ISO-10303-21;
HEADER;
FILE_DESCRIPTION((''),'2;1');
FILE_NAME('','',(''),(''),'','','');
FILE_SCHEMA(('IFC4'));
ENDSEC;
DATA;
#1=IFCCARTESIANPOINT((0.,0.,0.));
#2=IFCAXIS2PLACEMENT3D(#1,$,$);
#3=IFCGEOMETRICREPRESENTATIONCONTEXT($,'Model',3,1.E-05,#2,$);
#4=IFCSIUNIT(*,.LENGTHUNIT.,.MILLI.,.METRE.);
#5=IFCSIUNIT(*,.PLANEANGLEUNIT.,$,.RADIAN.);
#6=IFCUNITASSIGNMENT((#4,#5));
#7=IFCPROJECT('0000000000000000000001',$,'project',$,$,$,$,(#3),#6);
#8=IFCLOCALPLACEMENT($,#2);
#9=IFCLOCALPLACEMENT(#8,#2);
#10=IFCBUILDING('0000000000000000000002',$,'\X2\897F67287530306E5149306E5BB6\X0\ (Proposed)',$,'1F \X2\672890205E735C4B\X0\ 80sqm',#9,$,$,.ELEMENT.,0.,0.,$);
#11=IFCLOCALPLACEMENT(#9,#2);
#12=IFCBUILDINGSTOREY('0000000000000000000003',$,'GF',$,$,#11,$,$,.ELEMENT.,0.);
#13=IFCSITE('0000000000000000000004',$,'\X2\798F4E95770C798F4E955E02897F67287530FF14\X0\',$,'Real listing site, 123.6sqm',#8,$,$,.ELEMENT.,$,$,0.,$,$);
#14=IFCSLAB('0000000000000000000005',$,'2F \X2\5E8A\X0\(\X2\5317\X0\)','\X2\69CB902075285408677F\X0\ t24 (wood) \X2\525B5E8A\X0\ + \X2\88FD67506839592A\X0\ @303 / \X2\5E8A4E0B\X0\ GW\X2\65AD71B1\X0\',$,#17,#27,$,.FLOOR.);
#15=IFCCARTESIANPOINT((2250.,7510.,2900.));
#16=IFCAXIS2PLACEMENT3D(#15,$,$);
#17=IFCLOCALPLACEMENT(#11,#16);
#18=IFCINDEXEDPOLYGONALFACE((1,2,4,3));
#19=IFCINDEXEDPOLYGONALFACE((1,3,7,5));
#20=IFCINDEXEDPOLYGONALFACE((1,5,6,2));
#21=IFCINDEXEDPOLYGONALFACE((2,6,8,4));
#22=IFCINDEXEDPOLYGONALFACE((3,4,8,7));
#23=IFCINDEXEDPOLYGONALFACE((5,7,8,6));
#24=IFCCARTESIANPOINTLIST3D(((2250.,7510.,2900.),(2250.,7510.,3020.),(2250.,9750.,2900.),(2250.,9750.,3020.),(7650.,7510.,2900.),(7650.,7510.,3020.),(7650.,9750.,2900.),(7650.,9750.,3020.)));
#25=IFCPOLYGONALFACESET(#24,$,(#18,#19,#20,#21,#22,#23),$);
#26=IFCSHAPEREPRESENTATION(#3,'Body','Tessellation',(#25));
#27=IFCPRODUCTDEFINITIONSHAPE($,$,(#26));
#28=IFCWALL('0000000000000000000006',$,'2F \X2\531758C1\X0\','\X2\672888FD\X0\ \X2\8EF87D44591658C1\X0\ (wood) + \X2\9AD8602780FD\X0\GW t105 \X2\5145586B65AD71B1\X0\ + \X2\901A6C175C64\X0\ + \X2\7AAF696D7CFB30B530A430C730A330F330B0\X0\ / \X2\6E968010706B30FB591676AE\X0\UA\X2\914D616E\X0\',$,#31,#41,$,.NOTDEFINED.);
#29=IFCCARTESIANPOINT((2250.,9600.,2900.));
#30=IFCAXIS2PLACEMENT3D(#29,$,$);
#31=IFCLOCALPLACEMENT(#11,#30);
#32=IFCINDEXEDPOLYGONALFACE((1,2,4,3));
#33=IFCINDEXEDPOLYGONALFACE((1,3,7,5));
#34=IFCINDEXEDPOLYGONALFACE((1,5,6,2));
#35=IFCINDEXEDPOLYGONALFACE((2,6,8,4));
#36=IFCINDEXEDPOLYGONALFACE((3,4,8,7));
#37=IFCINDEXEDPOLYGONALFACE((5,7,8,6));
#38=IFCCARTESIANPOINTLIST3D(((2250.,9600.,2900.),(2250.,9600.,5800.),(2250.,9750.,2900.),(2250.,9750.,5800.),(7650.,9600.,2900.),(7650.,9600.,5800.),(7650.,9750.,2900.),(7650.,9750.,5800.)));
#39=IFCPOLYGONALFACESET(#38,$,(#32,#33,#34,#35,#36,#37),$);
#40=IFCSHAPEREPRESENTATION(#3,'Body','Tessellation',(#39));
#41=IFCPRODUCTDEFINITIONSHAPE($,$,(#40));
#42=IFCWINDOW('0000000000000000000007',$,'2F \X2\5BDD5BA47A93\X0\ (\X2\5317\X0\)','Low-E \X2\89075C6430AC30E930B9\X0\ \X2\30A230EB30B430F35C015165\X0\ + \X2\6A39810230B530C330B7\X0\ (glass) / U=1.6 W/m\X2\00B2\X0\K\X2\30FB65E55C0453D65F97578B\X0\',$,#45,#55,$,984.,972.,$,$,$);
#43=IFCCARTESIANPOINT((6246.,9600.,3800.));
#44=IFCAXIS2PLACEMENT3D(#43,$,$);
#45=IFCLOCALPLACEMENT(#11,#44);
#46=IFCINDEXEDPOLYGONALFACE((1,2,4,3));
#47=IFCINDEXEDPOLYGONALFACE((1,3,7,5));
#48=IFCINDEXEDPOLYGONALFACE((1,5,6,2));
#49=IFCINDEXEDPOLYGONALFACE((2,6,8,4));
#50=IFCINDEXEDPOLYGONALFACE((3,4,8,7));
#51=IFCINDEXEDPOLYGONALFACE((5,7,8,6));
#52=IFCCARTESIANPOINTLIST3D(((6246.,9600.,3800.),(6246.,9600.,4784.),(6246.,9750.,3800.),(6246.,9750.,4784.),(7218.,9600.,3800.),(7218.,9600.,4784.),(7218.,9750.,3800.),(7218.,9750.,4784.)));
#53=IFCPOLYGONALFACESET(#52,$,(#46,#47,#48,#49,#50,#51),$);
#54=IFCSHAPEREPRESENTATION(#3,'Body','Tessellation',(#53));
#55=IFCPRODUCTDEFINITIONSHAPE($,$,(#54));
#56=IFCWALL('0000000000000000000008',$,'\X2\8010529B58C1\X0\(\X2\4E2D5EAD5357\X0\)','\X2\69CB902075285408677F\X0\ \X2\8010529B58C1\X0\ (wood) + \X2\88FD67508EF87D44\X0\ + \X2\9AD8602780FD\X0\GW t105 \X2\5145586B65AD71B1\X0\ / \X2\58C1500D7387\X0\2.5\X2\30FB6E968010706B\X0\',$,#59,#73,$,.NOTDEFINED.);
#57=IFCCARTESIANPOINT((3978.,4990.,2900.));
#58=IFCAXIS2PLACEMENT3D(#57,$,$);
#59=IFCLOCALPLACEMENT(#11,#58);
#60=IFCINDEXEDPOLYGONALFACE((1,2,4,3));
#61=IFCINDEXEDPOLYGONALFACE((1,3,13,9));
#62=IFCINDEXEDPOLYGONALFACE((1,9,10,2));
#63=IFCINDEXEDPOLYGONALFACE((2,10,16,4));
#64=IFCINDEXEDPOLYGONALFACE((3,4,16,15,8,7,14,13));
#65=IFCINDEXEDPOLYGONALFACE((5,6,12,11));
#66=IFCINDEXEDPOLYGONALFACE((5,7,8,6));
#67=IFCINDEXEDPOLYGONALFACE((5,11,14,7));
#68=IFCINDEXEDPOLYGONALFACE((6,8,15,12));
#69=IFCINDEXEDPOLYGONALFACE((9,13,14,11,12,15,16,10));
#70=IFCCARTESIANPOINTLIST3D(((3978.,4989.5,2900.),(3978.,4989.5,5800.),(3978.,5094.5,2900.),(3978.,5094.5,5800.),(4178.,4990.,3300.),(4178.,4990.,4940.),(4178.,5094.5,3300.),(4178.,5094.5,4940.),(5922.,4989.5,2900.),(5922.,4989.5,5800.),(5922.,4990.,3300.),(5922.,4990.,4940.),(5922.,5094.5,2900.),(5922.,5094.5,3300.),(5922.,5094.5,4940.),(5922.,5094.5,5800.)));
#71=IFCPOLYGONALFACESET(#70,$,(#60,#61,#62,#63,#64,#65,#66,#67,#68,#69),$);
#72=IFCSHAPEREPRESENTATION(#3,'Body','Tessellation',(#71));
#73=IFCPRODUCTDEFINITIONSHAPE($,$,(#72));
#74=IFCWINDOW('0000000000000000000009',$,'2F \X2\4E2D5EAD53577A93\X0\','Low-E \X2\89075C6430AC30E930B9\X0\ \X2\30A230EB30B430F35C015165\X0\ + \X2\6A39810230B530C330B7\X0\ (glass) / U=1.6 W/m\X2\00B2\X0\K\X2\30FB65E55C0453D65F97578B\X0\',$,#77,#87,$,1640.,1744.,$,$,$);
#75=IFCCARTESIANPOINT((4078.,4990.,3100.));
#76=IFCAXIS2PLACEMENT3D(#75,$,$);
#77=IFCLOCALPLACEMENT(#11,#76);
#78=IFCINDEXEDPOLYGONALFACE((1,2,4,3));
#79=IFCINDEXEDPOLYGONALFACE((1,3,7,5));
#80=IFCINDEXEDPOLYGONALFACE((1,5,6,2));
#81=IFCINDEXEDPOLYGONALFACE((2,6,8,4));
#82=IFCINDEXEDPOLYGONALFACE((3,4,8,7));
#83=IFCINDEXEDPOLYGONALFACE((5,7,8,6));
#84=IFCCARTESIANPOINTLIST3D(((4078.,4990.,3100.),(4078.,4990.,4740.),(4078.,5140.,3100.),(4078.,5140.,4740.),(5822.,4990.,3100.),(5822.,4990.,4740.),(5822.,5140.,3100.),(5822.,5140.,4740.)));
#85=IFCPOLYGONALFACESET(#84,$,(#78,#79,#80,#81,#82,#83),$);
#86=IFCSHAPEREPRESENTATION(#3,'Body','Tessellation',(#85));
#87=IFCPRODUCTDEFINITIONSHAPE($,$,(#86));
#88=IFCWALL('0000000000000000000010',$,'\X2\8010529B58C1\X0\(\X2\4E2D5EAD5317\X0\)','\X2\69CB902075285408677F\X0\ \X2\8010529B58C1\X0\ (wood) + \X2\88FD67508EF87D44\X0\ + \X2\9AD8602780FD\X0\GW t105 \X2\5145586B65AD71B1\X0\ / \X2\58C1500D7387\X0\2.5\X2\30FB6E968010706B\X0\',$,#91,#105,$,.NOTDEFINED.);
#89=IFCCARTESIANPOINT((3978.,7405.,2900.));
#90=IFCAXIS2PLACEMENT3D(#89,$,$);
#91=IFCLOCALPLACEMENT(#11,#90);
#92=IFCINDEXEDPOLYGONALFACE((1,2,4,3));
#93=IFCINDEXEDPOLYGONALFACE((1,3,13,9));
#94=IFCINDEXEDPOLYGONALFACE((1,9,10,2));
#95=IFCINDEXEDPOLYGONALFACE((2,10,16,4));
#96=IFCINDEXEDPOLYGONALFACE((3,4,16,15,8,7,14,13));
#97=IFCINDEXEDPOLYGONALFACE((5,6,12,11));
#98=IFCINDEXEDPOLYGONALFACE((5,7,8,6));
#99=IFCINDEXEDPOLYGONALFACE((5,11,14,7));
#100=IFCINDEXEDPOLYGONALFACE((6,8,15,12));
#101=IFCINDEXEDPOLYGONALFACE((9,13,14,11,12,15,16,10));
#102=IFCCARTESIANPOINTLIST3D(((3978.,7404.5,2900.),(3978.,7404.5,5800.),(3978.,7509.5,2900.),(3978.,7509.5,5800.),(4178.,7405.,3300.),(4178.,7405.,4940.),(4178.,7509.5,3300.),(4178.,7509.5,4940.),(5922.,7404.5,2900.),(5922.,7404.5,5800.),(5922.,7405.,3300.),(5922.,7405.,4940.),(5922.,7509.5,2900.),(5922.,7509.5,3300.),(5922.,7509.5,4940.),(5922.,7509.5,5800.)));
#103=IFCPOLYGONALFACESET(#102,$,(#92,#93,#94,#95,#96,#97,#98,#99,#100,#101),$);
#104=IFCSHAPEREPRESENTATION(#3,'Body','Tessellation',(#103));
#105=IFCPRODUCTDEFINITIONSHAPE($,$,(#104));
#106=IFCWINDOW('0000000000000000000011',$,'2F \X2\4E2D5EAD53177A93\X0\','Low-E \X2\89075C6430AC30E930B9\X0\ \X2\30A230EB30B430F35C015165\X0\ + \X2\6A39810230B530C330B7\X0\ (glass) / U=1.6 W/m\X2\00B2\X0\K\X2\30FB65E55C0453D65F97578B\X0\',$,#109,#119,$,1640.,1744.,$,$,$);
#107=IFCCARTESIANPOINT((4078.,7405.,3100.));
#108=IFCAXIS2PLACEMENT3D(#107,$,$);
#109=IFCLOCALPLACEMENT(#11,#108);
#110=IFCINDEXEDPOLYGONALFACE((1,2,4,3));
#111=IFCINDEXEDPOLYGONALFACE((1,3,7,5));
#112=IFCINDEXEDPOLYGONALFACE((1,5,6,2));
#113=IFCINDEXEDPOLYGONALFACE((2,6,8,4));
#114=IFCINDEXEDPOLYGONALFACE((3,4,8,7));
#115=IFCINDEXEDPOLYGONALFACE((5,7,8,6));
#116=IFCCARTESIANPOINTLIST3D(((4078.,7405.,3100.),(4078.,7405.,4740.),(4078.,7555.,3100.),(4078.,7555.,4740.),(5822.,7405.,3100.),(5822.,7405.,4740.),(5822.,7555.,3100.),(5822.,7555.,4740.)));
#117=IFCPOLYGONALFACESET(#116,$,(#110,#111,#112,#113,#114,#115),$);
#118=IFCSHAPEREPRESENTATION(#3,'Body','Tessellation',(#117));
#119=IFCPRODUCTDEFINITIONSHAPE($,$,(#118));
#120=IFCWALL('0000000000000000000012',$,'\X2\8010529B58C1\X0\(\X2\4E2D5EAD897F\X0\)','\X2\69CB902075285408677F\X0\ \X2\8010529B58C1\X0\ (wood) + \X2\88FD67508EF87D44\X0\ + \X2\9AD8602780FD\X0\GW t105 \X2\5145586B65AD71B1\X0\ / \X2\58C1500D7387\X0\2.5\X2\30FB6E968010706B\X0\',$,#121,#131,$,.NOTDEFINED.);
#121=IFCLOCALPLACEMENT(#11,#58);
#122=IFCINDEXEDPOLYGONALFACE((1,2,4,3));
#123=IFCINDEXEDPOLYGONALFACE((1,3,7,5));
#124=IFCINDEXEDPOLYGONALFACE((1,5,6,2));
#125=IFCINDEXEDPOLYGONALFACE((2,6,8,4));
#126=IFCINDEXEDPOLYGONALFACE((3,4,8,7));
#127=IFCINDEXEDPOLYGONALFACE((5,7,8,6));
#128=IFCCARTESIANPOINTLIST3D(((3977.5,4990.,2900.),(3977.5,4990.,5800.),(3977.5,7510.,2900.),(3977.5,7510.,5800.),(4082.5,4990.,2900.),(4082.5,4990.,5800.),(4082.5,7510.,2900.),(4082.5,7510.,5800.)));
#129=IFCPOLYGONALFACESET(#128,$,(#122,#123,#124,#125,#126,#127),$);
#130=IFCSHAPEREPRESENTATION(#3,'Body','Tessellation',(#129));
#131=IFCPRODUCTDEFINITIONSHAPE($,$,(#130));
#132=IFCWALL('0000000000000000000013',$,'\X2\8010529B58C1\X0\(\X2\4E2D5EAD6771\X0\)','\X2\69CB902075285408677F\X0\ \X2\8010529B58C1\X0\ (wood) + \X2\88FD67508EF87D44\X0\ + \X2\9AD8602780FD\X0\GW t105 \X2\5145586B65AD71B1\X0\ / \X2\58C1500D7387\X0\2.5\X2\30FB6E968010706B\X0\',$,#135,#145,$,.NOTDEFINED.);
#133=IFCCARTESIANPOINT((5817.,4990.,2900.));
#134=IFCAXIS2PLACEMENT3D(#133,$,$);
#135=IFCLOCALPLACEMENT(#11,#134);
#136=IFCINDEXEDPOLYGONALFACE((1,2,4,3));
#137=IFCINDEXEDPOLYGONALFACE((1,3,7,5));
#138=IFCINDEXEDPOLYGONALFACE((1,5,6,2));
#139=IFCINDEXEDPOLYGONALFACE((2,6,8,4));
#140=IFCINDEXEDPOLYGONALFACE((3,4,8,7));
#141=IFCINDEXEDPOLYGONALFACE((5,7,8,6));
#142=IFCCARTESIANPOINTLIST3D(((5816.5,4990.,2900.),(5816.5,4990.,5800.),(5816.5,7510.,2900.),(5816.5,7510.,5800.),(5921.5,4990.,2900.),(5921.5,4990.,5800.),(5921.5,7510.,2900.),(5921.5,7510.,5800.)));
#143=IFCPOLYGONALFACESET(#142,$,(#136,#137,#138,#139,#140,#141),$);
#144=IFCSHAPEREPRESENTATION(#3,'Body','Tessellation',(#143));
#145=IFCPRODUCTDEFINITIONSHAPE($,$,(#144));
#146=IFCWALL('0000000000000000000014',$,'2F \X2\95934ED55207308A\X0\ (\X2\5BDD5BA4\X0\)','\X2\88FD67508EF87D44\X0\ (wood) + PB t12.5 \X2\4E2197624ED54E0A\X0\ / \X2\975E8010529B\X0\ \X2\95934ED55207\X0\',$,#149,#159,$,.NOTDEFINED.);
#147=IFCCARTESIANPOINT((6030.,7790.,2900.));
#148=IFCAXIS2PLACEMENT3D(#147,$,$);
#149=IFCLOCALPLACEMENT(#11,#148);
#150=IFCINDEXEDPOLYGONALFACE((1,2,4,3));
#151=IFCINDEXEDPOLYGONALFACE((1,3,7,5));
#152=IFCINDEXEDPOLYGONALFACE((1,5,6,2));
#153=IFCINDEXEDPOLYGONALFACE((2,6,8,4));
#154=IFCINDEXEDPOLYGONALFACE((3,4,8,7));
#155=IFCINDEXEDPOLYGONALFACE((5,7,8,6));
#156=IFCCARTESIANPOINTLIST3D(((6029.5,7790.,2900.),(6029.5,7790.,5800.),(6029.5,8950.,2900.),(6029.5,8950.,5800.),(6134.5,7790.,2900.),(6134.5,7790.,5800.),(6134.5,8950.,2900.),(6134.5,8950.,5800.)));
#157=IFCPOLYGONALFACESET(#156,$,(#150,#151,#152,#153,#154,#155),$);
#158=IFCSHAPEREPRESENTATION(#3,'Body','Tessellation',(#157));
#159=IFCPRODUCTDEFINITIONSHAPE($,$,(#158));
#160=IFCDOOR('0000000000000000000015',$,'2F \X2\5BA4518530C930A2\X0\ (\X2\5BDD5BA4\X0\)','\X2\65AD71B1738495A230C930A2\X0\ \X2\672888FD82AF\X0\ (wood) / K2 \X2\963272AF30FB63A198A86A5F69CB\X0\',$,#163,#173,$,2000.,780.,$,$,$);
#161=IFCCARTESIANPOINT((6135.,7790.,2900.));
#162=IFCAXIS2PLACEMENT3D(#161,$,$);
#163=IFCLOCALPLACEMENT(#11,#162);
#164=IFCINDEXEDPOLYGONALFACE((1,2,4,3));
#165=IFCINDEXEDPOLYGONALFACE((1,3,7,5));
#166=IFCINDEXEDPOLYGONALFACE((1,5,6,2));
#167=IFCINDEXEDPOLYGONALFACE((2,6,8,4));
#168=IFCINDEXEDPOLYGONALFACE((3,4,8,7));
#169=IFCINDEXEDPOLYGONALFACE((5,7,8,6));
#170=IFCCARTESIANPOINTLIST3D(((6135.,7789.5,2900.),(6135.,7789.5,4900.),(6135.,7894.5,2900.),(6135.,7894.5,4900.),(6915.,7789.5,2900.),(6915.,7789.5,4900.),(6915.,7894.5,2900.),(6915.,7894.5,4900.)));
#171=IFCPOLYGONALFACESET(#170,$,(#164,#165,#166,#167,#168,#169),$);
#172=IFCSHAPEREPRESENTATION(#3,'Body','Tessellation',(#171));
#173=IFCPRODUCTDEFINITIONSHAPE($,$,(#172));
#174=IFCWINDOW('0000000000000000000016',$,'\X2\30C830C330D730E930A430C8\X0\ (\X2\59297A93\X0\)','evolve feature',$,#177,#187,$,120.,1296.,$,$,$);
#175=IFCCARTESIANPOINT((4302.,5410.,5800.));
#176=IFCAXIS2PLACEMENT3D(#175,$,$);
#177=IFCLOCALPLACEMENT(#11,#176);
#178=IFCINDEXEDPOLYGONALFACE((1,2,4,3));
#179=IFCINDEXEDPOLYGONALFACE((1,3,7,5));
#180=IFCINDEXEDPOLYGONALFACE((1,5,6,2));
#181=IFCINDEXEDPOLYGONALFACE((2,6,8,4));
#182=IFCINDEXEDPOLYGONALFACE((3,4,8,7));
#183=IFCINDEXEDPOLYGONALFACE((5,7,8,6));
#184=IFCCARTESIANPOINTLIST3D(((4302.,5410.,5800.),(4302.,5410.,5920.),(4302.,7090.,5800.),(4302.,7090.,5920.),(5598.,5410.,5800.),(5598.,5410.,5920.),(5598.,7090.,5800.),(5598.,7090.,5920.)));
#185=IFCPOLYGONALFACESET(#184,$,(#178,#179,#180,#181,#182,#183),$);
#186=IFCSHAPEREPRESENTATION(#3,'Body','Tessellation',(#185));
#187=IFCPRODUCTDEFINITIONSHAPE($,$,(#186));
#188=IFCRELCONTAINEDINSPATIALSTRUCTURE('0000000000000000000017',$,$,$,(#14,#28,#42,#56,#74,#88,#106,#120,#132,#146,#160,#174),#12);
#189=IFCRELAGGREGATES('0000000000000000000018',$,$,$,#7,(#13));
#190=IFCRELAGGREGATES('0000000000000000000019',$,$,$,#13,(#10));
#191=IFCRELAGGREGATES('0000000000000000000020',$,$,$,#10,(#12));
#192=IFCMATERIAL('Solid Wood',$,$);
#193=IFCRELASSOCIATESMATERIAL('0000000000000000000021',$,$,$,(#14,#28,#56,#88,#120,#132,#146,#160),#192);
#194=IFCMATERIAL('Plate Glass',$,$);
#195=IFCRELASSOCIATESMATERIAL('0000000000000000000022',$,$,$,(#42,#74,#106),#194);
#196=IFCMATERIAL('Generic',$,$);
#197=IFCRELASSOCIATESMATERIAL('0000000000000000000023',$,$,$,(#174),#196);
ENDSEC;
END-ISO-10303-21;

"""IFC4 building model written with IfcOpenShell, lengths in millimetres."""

from ifc_helpers import new_model, si_unit, frame, frame_2d, origin, place, context, project, spatial, rectangle, extrude, material, element, fill, save


model = new_model("IFC4")

# Units and contexts
model_context = context("Model", 3, precision=1e-05, world=origin())
ifc_project = project(units=[si_unit("LENGTHUNIT", "METRE", prefix="MILLI"), si_unit("PLANEANGLEUNIT", "RADIAN")], contexts=[model_context])

# Site, building, storey
site_placement = place(None, origin())
site = spatial("IfcSite", under=ifc_project, at=site_placement, Name="福井県福井市西木田４", ObjectType="Real listing site, 123.6sqm", CompositionType="ELEMENT", RefElevation=0.0)
building_placement = place(site_placement, origin())
building = spatial("IfcBuilding", under=site, at=building_placement, Name="西木田の光の家 (Proposed)", ObjectType="1F 木造平屋 80sqm", CompositionType="ELEMENT", ElevationOfRefHeight=0.0, ElevationOfTerrain=0.0)
storey_placement = place(building_placement, origin())
storey = spatial("IfcBuildingStorey", under=building, at=storey_placement, Name="GF", CompositionType="ELEMENT", Elevation=0.0)

# Slab
ifc_material_1 = material(Name="Solid Wood")
slab_placement = place(storey_placement, frame((2250.0, 7510.0, 2900.0)))
element("IfcSlab", 1, at=slab_placement, inside=storey, material=ifc_material_1, Name="2F 床(北)", Description="構造用合板 t24 (wood) 剛床 + 製材根太 @303 / 床下 GW断熱", PredefinedType="FLOOR", context=model_context, shape_type="SweptSolid", body=[
    extrude(rectangle(XDim=5400.0, YDim=2240.0, at=frame_2d((2700.0, 1120.0))), frame((2250.0, 7510.0, 2900.0)), (0.0, 0.0, 1.0), 120.0),
])

# Walls, openings, windows
wall_1_placement = place(storey_placement, frame((2250.0, 9600.0, 2900.0)))
wall_1 = element("IfcWall", 2, at=wall_1_placement, inside=storey, material=ifc_material_1, Name="2F 北壁", Description="木製 軸組外壁 (wood) + 高性能GW t105 充填断熱 + 通気層 + 窯業系サイディング / 準耐火・外皮UA配慮", PredefinedType="NOTDEFINED", context=model_context, shape_type="SweptSolid", body=[
    extrude(rectangle(XDim=5400.0, YDim=150.0, at=frame_2d((2700.0, 75.0))), frame((2250.0, 9600.0, 2900.0)), (0.0, 0.0, 1.0), 2900.0),
])
opening_1_placement = place(storey_placement, frame((6246.0, 9600.0, 3800.0)))
opening_1 = element("IfcOpeningElement", 3, at=opening_1_placement, cuts=wall_1, PredefinedType="NOTDEFINED", context=model_context, shape_type="SweptSolid", body=[
    extrude(rectangle(XDim=972.0, YDim=150.0, at=frame_2d((486.0, 75.0))), frame((6246.0, 9600.0, 3800.0)), (0.0, 0.0, 1.0), 984.0),
])
ifc_material_2 = material(Name="Plate Glass")
window_1_placement = place(storey_placement, frame((6246.0, 9600.0, 3800.0)))
window_1 = element("IfcWindow", 4, at=window_1_placement, inside=storey, material=ifc_material_2, Name="2F 寝室窓 (北)", Description="Low-E 複層ガラス アルゴン封入 + 樹脂サッシ (glass) / U=1.6 W/m²K・日射取得型", OverallHeight=984.0, OverallWidth=972.0, context=model_context, shape_type="SweptSolid", body=[
    extrude(rectangle(XDim=972.0, YDim=150.0, at=frame_2d((486.0, 75.0))), frame((6246.0, 9600.0, 3800.0)), (0.0, 0.0, 1.0), 984.0),
])
fill(opening_1, window_1)
wall_2_placement = place(storey_placement, frame((3978.0, 4990.0, 2900.0)))
wall_2 = element("IfcWall", 5, at=wall_2_placement, inside=storey, material=ifc_material_1, Name="耐力壁(中庭南)", Description="構造用合板 耐力壁 (wood) + 製材軸組 + 高性能GW t105 充填断熱 / 壁倍率2.5・準耐火", PredefinedType="NOTDEFINED", context=model_context, shape_type="SweptSolid", body=[
    extrude(rectangle(XDim=1944.0, YDim=105.0, at=frame_2d((972.0, 52.0))), frame((3978.0, 4990.0, 2900.0)), (0.0, 0.0, 1.0), 2900.0),
])
opening_2_placement = place(storey_placement, frame((4078.0, 4990.0, 3100.0)))
opening_2 = element("IfcOpeningElement", 6, at=opening_2_placement, cuts=wall_2, PredefinedType="NOTDEFINED", context=model_context, shape_type="SweptSolid", body=[
    extrude(rectangle(XDim=1744.0, YDim=150.0, at=frame_2d((872.0, 75.0))), frame((4078.0, 4990.0, 3100.0)), (0.0, 0.0, 1.0), 1640.0),
])
window_2_placement = place(storey_placement, frame((4078.0, 4990.0, 3100.0)))
window_2 = element("IfcWindow", 7, at=window_2_placement, inside=storey, material=ifc_material_2, Name="2F 中庭南窓", Description="Low-E 複層ガラス アルゴン封入 + 樹脂サッシ (glass) / U=1.6 W/m²K・日射取得型", OverallHeight=1640.0, OverallWidth=1744.0, context=model_context, shape_type="SweptSolid", body=[
    extrude(rectangle(XDim=1744.0, YDim=150.0, at=frame_2d((872.0, 75.0))), frame((4078.0, 4990.0, 3100.0)), (0.0, 0.0, 1.0), 1640.0),
])
fill(opening_2, window_2)
wall_3_placement = place(storey_placement, frame((3978.0, 7405.0, 2900.0)))
wall_3 = element("IfcWall", 8, at=wall_3_placement, inside=storey, material=ifc_material_1, Name="耐力壁(中庭北)", Description="構造用合板 耐力壁 (wood) + 製材軸組 + 高性能GW t105 充填断熱 / 壁倍率2.5・準耐火", PredefinedType="NOTDEFINED", context=model_context, shape_type="SweptSolid", body=[
    extrude(rectangle(XDim=1944.0, YDim=105.0, at=frame_2d((972.0, 52.0))), frame((3978.0, 7405.0, 2900.0)), (0.0, 0.0, 1.0), 2900.0),
])
opening_3_placement = place(storey_placement, frame((4078.0, 7405.0, 3100.0)))
opening_3 = element("IfcOpeningElement", 9, at=opening_3_placement, cuts=wall_3, PredefinedType="NOTDEFINED", context=model_context, shape_type="SweptSolid", body=[
    extrude(rectangle(XDim=1744.0, YDim=150.0, at=frame_2d((872.0, 75.0))), frame((4078.0, 7405.0, 3100.0)), (0.0, 0.0, 1.0), 1640.0),
])
window_3_placement = place(storey_placement, frame((4078.0, 7405.0, 3100.0)))
window_3 = element("IfcWindow", 10, at=window_3_placement, inside=storey, material=ifc_material_2, Name="2F 中庭北窓", Description="Low-E 複層ガラス アルゴン封入 + 樹脂サッシ (glass) / U=1.6 W/m²K・日射取得型", OverallHeight=1640.0, OverallWidth=1744.0, context=model_context, shape_type="SweptSolid", body=[
    extrude(rectangle(XDim=1744.0, YDim=150.0, at=frame_2d((872.0, 75.0))), frame((4078.0, 7405.0, 3100.0)), (0.0, 0.0, 1.0), 1640.0),
])
fill(opening_3, window_3)

# Walls
wall_4_placement = place(storey_placement, frame((3978.0, 4990.0, 2900.0)))
element("IfcWall", 11, at=wall_4_placement, inside=storey, material=ifc_material_1, Name="耐力壁(中庭西)", Description="構造用合板 耐力壁 (wood) + 製材軸組 + 高性能GW t105 充填断熱 / 壁倍率2.5・準耐火", PredefinedType="NOTDEFINED", context=model_context, shape_type="SweptSolid", body=[
    extrude(rectangle(XDim=105.0, YDim=2520.0, at=frame_2d((52.0, 1260.0))), frame((3978.0, 4990.0, 2900.0)), (0.0, 0.0, 1.0), 2900.0),
])
wall_5_placement = place(storey_placement, frame((5817.0, 4990.0, 2900.0)))
element("IfcWall", 12, at=wall_5_placement, inside=storey, material=ifc_material_1, Name="耐力壁(中庭東)", Description="構造用合板 耐力壁 (wood) + 製材軸組 + 高性能GW t105 充填断熱 / 壁倍率2.5・準耐火", PredefinedType="NOTDEFINED", context=model_context, shape_type="SweptSolid", body=[
    extrude(rectangle(XDim=105.0, YDim=2520.0, at=frame_2d((52.0, 1260.0))), frame((5817.0, 4990.0, 2900.0)), (0.0, 0.0, 1.0), 2900.0),
])
wall_6_placement = place(storey_placement, frame((6030.0, 7790.0, 2900.0)))
element("IfcWall", 13, at=wall_6_placement, inside=storey, material=ifc_material_1, Name="2F 間仕切り (寝室)", Description="製材軸組 (wood) + PB t12.5 両面仕上 / 非耐力 間仕切", PredefinedType="NOTDEFINED", context=model_context, shape_type="SweptSolid", body=[
    extrude(rectangle(XDim=105.0, YDim=1160.0, at=frame_2d((52.0, 580.0))), frame((6030.0, 7790.0, 2900.0)), (0.0, 0.0, 1.0), 2900.0),
])

# Door
door_placement = place(storey_placement, frame((6135.0, 7790.0, 2900.0)))
element("IfcDoor", 14, at=door_placement, inside=storey, material=ifc_material_1, Name="2F 室内ドア (寝室)", Description="断熱玄関ドア 木製芯 (wood) / K2 防犯・採風機構", OverallHeight=2000.0, OverallWidth=780.0, context=model_context, shape_type="SweptSolid", body=[
    extrude(rectangle(XDim=780.0, YDim=105.0, at=frame_2d((390.0, 52.0))), frame((6135.0, 7790.0, 2900.0)), (0.0, 0.0, 1.0), 2000.0),
])

# Window
ifc_material_3 = material(Name="Generic")
window_4_placement = place(storey_placement, frame((4302.0, 5410.0, 5800.0)))
element("IfcWindow", 15, at=window_4_placement, inside=storey, material=ifc_material_3, Name="トップライト (天窓)", Description="evolve feature", OverallHeight=120.0, OverallWidth=1296.0, context=model_context, shape_type="SweptSolid", body=[
    extrude(rectangle(XDim=1296.0, YDim=1680.0, at=frame_2d((648.0, 840.0))), frame((4302.0, 5410.0, 5800.0)), (0.0, 0.0, 1.0), 120.0),
])

save(model, "model.ifc")
